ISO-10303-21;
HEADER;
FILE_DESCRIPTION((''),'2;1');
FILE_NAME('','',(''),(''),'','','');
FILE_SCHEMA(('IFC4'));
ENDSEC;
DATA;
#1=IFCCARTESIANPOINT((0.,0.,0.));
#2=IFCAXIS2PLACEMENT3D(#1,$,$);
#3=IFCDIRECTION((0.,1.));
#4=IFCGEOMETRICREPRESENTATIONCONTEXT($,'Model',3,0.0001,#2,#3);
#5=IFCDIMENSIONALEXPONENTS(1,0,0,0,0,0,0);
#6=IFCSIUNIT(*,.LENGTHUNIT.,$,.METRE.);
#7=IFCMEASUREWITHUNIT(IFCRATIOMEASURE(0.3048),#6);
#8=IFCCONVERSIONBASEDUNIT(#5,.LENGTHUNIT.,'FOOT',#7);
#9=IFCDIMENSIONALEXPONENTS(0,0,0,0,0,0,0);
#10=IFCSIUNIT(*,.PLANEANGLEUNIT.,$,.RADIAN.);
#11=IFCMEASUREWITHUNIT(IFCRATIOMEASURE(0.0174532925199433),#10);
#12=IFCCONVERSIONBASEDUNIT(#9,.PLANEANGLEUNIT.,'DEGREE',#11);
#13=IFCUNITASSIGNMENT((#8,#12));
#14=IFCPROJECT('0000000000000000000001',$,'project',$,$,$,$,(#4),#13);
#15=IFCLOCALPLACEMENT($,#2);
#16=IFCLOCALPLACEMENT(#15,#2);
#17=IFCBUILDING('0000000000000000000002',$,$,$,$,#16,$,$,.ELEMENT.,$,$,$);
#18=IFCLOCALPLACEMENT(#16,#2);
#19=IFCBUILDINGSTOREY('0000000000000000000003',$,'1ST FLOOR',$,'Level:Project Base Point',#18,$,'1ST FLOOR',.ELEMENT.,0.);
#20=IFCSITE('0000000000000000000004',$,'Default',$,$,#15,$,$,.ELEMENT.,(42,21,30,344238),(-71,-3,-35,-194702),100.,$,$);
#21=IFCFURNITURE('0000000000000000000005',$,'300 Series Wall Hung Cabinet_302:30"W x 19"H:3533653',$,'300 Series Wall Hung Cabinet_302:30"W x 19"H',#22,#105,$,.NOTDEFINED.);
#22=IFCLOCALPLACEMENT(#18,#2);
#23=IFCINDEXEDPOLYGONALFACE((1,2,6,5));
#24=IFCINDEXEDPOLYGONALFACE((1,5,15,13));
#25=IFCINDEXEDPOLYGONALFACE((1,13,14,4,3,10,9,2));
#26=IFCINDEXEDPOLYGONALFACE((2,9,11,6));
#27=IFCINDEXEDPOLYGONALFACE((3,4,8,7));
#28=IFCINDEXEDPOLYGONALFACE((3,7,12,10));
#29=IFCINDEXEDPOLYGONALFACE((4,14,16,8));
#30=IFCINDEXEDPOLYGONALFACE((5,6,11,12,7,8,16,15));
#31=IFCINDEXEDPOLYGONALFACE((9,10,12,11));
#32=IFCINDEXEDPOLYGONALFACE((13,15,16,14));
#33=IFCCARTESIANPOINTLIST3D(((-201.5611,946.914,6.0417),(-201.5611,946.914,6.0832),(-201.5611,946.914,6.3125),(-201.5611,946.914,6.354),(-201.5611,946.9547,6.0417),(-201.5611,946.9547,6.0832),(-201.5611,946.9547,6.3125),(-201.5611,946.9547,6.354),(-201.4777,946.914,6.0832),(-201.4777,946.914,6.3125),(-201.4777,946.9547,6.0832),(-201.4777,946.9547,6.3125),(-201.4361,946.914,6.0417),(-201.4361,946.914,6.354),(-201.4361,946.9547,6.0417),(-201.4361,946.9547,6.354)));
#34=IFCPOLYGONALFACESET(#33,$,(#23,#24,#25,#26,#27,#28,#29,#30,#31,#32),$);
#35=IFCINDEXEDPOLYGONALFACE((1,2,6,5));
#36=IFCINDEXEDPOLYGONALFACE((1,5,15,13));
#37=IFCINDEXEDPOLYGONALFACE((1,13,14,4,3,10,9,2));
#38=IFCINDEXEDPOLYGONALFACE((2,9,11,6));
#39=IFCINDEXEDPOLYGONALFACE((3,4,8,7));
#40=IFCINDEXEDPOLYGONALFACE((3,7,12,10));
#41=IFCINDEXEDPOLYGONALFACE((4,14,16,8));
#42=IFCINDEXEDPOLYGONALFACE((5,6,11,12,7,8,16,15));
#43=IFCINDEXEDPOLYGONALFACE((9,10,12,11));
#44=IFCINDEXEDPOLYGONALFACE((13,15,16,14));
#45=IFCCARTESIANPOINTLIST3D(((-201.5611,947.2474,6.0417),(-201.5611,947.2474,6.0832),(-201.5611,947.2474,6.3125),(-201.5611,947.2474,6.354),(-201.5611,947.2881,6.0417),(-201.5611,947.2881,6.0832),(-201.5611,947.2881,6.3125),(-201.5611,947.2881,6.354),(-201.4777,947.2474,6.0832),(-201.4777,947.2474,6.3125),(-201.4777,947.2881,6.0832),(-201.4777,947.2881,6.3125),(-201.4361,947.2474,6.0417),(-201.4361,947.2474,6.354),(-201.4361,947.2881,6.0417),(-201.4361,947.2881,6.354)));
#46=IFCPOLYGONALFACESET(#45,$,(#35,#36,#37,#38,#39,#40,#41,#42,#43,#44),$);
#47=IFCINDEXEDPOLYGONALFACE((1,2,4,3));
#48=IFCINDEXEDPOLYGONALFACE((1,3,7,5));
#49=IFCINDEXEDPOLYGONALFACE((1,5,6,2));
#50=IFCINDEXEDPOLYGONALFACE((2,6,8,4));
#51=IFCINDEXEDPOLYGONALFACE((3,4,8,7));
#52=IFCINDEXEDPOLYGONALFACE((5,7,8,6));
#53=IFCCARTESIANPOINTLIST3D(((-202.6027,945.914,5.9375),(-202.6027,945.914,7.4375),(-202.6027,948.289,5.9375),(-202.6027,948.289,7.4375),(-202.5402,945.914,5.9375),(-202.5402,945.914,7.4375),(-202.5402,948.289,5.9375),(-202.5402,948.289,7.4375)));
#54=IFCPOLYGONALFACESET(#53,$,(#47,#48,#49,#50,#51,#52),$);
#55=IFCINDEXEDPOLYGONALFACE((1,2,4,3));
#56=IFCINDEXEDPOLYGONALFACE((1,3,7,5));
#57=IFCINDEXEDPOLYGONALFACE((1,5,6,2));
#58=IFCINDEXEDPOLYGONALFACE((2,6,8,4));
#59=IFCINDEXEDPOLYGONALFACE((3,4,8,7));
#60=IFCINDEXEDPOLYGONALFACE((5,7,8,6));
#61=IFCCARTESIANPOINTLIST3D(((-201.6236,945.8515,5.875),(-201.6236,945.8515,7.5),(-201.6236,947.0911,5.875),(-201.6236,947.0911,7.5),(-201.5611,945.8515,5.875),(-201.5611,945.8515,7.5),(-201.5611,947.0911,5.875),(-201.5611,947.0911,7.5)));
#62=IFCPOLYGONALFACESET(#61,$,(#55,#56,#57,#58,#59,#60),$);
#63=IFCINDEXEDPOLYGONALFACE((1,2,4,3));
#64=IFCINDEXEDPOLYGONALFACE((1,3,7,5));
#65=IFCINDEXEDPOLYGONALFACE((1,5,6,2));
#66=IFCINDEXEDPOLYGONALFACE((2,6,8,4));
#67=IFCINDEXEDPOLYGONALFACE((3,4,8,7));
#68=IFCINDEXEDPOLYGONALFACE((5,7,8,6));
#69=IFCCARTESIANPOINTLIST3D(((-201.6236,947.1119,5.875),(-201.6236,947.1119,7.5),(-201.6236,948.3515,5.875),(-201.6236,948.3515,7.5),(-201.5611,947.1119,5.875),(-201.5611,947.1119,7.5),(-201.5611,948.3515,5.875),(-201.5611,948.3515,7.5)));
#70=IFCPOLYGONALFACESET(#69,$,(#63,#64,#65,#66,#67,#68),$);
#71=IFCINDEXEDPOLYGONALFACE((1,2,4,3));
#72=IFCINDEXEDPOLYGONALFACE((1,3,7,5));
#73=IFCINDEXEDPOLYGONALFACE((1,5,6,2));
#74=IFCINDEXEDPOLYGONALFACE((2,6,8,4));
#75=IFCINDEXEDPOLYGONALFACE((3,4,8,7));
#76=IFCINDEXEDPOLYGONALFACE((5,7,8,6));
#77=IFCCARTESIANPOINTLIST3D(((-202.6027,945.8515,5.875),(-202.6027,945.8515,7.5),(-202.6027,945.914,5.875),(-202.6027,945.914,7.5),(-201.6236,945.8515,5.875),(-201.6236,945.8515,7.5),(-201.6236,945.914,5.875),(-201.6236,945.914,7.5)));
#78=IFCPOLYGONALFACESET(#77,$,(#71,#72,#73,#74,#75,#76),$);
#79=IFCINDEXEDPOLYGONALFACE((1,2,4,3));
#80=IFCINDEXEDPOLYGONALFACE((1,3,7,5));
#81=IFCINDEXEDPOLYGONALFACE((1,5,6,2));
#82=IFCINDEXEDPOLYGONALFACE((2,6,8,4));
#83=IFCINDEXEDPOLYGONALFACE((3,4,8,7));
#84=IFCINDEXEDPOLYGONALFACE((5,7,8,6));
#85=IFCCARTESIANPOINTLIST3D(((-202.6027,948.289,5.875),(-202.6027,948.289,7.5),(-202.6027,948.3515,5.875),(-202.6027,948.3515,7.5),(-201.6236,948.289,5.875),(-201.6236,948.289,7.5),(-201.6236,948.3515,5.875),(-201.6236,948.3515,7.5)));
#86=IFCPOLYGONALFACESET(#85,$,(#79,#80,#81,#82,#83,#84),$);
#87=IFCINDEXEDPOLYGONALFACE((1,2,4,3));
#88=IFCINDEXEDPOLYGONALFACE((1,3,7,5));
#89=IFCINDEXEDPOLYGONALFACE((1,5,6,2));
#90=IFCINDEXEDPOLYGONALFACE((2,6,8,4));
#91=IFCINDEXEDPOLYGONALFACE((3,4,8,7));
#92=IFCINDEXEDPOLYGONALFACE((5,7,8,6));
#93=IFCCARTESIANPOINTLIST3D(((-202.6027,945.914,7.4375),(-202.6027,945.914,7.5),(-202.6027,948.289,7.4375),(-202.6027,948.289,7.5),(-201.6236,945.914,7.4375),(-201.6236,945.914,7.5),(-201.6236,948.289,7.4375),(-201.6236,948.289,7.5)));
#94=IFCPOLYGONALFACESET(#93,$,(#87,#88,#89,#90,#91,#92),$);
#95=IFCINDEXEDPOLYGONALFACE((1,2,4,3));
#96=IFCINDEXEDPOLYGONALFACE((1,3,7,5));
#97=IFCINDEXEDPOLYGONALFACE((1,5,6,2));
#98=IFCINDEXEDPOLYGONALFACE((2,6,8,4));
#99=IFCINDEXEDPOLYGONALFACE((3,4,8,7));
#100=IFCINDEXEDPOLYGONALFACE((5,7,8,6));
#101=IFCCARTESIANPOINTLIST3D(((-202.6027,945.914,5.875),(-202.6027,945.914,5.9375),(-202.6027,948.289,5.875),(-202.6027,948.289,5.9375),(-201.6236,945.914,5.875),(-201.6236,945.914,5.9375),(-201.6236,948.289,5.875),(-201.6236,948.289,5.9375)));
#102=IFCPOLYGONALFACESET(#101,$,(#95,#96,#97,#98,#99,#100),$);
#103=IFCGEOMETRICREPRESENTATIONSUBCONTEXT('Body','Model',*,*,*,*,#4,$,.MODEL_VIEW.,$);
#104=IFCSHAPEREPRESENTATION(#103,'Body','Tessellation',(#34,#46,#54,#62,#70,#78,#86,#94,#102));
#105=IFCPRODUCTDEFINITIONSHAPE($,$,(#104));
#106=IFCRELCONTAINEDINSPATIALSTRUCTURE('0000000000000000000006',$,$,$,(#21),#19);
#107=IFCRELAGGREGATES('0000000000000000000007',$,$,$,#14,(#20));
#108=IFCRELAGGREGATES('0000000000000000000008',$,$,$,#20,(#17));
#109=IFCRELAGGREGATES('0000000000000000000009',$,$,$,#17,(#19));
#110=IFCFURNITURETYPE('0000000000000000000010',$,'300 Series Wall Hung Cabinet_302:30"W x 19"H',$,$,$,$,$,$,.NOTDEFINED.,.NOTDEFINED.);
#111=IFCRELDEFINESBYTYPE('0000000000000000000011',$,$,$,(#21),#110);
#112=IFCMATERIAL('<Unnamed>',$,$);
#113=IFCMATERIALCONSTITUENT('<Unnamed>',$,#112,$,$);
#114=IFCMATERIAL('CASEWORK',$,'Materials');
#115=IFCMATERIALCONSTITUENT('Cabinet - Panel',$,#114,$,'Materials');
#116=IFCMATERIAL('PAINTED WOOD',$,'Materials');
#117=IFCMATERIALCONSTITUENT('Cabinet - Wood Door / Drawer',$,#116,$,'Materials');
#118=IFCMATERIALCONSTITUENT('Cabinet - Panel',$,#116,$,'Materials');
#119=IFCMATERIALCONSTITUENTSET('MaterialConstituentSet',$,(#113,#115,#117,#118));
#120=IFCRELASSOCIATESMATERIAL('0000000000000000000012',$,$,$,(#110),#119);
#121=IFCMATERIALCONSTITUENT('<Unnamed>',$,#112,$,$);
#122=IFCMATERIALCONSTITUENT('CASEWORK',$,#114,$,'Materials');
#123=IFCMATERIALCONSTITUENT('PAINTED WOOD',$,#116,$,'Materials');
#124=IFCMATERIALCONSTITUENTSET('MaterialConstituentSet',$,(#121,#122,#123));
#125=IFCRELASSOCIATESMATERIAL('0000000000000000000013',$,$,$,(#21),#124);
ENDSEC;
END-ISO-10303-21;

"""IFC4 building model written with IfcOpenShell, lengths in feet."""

from ifc_helpers import new_model, entity, si_unit, converted_unit, direction, frame, frame_2d, origin, origin_2d_with_axis, place, context, subcontext, project, spatial, polyline, rectangle, outline, extrude, source, transform, mapped, material, constituent, constituent_set, type_object, type_shapes, element, save


model = new_model("IFC4")

# Units and contexts
model_context = context("Model", 3, precision=0.0001, world=origin(), true_north=direction((0.0, 1.0)))
body_context = subcontext(model_context, "Body", "Model", "MODEL_VIEW")
ifc_project = project(units=[converted_unit("LENGTHUNIT", "FOOT", entity("IfcRatioMeasure", 0.3048), si_unit("LENGTHUNIT", "METRE"), dimensions=[1, 0, 0, 0, 0, 0, 0]), converted_unit("PLANEANGLEUNIT", "DEGREE", entity("IfcRatioMeasure", 0.0174532925199433), si_unit("PLANEANGLEUNIT", "RADIAN"), dimensions=[0, 0, 0, 0, 0, 0, 0])], contexts=[model_context])

# Site, building, storey
site_placement = place(None, origin())
site = spatial("IfcSite", under=ifc_project, at=site_placement, Name="Default", CompositionType="ELEMENT", RefLatitude=(42, 21, 30, 344238), RefLongitude=(-71, -3, -35, -194702), RefElevation=100.0)
building_placement = place(site_placement, origin())
building = spatial("IfcBuilding", under=site, at=building_placement, CompositionType="ELEMENT")
storey_placement = place(building_placement, origin())
storey = spatial("IfcBuildingStorey", under=building, at=storey_placement, Name="1ST FLOOR", ObjectType="Level:Project Base Point", LongName="1ST FLOOR", CompositionType="ELEMENT", Elevation=0.0)

# Shared definitions
ifc_material_1 = material(Name="<Unnamed>")

# Shared definitions
ifc_material_2 = material(Name="PAINTED WOOD", Category="Materials")
ifc_material_3 = material(Name="CASEWORK", Category="Materials")

# Furniture
ifc_constituent_1 = constituent(ifc_material_1, Name="<Unnamed>")
ifc_constituent_2 = constituent(ifc_material_3, Name="CASEWORK", Category="Materials")
ifc_constituent_3 = constituent(ifc_material_2, Name="PAINTED WOOD", Category="Materials")
ifc_constituent_set_1 = constituent_set(constituents=[ifc_constituent_1, ifc_constituent_2, ifc_constituent_3], Name="MaterialConstituentSet")
ifc_constituent_4 = constituent(ifc_material_1, Name="<Unnamed>")
ifc_constituent_5 = constituent(ifc_material_3, Name="Cabinet - Panel", Category="Materials")
ifc_constituent_6 = constituent(ifc_material_2, Name="Cabinet - Wood Door / Drawer", Category="Materials")
ifc_constituent_7 = constituent(ifc_material_2, Name="Cabinet - Panel", Category="Materials")
ifc_constituent_set_2 = constituent_set(constituents=[ifc_constituent_4, ifc_constituent_5, ifc_constituent_6, ifc_constituent_7], Name="MaterialConstituentSet")
furniture_type_1 = type_object("IfcFurnitureType", Name="300 Series Wall Hung Cabinet_302:30\"W x 19\"H", AssemblyPlace="NOTDEFINED", PredefinedType="NOTDEFINED", material=ifc_constituent_set_2)
shared_shape_1 = source(origin(), body_context, "Body", "SweptSolid", [
    extrude(outline(polyline([(0.1146, -0.0521), (0.1562, -0.0521), (0.1562, 0.0729), (-0.1562, 0.0729), (-0.1562, -0.0521), (-0.1146, -0.0521), (-0.1146, 0.0313), (0.1146, 0.0313), (0.1146, -0.0521)])), frame((1.0625, 0.0729, 0.3229), z_axis=(1.0, 0.0, 0.0), x_axis=(0.0, 0.0, 1.0)), (0.0, 0.0, 1.0), 0.0407),
    extrude(outline(polyline([(0.1146, -0.0521), (0.1562, -0.0521), (0.1562, 0.0729), (-0.1562, 0.0729), (-0.1562, -0.0521), (-0.1146, -0.0521), (-0.1146, 0.0313), (0.1146, 0.0313), (0.1146, -0.0521)])), frame((1.3958, 0.0729, 0.3229), z_axis=(1.0, 0.0, 0.0), x_axis=(0.0, 0.0, 1.0)), (0.0, 0.0, 1.0), 0.0407),
    extrude(rectangle(XDim=2.375, YDim=0.0625, at=origin_2d_with_axis()), frame((1.25, 1.1354, 0.0625), z_axis=(0.0, 0.0, 1.0), x_axis=(-1.0, 0.0, 0.0)), (0.0, 0.0, 1.0), 1.5),
    extrude(rectangle(XDim=1.2396, YDim=0.0625, at=origin_2d_with_axis()), frame((0.6198, 0.1562, 0.0), z_axis=(0.0, 0.0, 1.0), x_axis=(-1.0, 0.0, 0.0)), (0.0, 0.0, 1.0), 1.625),
    extrude(rectangle(XDim=1.2396, YDim=0.0625, at=frame_2d((0.0, 0.0), x_axis=(1.0, 0.0))), frame((1.8802, 0.1562, 0.0), z_axis=(0.0, 0.0, 1.0), x_axis=(-1.0, 0.0, 0.0)), (0.0, 0.0, 1.0), 1.625),
    extrude(rectangle(XDim=0.9792, YDim=0.0625, at=frame_2d((0.0, 0.0), x_axis=(1.0, 0.0))), frame((0.0313, 0.677, 0.0), z_axis=(0.0, 0.0, 1.0), x_axis=(0.0, -1.0, 0.0)), (0.0, 0.0, 1.0), 1.625),
    extrude(rectangle(XDim=0.9792, YDim=0.0625, at=frame_2d((0.0, 0.0), x_axis=(1.0, 0.0))), frame((2.4688, 0.677, 0.0), z_axis=(0.0, 0.0, 1.0), x_axis=(0.0, -1.0, 0.0)), (0.0, 0.0, 1.0), 1.625),
    extrude(rectangle(XDim=0.9792, YDim=2.375, at=frame_2d((0.0, 0.0), x_axis=(1.0, 0.0))), frame((1.25, 0.677, 1.5625), z_axis=(0.0, 0.0, 1.0), x_axis=(0.0, 1.0, 0.0)), (0.0, 0.0, 1.0), 0.0625),
    extrude(rectangle(XDim=0.9792, YDim=2.375, at=frame_2d((0.0, 0.0), x_axis=(1.0, 0.0))), frame((1.25, 0.677, 0.0), z_axis=(0.0, 0.0, 1.0), x_axis=(0.0, 1.0, 0.0)), (0.0, 0.0, 1.0), 0.0625),
])
type_shapes(furniture_type_1, [shared_shape_1])
furniture_1_placement = place(storey_placement, frame((-201.4361, 945.8515, 5.875), z_axis=(0.0, 0.0, 1.0), x_axis=(0.0, 1.0, 0.0)))
element("IfcFurniture", 1, at=furniture_1_placement, inside=storey, type_object=furniture_type_1, material=ifc_constituent_set_1, Name="300 Series Wall Hung Cabinet_302:30\"W x 19\"H:3533653", ObjectType="300 Series Wall Hung Cabinet_302:30\"W x 19\"H", PredefinedType="NOTDEFINED", context=body_context, shape_type="MappedRepresentation", body=[
    mapped(shared_shape_1, transform((0.0, 0.0, 0.0), scale=1.0)),
])

save(model, "model.ifc")
